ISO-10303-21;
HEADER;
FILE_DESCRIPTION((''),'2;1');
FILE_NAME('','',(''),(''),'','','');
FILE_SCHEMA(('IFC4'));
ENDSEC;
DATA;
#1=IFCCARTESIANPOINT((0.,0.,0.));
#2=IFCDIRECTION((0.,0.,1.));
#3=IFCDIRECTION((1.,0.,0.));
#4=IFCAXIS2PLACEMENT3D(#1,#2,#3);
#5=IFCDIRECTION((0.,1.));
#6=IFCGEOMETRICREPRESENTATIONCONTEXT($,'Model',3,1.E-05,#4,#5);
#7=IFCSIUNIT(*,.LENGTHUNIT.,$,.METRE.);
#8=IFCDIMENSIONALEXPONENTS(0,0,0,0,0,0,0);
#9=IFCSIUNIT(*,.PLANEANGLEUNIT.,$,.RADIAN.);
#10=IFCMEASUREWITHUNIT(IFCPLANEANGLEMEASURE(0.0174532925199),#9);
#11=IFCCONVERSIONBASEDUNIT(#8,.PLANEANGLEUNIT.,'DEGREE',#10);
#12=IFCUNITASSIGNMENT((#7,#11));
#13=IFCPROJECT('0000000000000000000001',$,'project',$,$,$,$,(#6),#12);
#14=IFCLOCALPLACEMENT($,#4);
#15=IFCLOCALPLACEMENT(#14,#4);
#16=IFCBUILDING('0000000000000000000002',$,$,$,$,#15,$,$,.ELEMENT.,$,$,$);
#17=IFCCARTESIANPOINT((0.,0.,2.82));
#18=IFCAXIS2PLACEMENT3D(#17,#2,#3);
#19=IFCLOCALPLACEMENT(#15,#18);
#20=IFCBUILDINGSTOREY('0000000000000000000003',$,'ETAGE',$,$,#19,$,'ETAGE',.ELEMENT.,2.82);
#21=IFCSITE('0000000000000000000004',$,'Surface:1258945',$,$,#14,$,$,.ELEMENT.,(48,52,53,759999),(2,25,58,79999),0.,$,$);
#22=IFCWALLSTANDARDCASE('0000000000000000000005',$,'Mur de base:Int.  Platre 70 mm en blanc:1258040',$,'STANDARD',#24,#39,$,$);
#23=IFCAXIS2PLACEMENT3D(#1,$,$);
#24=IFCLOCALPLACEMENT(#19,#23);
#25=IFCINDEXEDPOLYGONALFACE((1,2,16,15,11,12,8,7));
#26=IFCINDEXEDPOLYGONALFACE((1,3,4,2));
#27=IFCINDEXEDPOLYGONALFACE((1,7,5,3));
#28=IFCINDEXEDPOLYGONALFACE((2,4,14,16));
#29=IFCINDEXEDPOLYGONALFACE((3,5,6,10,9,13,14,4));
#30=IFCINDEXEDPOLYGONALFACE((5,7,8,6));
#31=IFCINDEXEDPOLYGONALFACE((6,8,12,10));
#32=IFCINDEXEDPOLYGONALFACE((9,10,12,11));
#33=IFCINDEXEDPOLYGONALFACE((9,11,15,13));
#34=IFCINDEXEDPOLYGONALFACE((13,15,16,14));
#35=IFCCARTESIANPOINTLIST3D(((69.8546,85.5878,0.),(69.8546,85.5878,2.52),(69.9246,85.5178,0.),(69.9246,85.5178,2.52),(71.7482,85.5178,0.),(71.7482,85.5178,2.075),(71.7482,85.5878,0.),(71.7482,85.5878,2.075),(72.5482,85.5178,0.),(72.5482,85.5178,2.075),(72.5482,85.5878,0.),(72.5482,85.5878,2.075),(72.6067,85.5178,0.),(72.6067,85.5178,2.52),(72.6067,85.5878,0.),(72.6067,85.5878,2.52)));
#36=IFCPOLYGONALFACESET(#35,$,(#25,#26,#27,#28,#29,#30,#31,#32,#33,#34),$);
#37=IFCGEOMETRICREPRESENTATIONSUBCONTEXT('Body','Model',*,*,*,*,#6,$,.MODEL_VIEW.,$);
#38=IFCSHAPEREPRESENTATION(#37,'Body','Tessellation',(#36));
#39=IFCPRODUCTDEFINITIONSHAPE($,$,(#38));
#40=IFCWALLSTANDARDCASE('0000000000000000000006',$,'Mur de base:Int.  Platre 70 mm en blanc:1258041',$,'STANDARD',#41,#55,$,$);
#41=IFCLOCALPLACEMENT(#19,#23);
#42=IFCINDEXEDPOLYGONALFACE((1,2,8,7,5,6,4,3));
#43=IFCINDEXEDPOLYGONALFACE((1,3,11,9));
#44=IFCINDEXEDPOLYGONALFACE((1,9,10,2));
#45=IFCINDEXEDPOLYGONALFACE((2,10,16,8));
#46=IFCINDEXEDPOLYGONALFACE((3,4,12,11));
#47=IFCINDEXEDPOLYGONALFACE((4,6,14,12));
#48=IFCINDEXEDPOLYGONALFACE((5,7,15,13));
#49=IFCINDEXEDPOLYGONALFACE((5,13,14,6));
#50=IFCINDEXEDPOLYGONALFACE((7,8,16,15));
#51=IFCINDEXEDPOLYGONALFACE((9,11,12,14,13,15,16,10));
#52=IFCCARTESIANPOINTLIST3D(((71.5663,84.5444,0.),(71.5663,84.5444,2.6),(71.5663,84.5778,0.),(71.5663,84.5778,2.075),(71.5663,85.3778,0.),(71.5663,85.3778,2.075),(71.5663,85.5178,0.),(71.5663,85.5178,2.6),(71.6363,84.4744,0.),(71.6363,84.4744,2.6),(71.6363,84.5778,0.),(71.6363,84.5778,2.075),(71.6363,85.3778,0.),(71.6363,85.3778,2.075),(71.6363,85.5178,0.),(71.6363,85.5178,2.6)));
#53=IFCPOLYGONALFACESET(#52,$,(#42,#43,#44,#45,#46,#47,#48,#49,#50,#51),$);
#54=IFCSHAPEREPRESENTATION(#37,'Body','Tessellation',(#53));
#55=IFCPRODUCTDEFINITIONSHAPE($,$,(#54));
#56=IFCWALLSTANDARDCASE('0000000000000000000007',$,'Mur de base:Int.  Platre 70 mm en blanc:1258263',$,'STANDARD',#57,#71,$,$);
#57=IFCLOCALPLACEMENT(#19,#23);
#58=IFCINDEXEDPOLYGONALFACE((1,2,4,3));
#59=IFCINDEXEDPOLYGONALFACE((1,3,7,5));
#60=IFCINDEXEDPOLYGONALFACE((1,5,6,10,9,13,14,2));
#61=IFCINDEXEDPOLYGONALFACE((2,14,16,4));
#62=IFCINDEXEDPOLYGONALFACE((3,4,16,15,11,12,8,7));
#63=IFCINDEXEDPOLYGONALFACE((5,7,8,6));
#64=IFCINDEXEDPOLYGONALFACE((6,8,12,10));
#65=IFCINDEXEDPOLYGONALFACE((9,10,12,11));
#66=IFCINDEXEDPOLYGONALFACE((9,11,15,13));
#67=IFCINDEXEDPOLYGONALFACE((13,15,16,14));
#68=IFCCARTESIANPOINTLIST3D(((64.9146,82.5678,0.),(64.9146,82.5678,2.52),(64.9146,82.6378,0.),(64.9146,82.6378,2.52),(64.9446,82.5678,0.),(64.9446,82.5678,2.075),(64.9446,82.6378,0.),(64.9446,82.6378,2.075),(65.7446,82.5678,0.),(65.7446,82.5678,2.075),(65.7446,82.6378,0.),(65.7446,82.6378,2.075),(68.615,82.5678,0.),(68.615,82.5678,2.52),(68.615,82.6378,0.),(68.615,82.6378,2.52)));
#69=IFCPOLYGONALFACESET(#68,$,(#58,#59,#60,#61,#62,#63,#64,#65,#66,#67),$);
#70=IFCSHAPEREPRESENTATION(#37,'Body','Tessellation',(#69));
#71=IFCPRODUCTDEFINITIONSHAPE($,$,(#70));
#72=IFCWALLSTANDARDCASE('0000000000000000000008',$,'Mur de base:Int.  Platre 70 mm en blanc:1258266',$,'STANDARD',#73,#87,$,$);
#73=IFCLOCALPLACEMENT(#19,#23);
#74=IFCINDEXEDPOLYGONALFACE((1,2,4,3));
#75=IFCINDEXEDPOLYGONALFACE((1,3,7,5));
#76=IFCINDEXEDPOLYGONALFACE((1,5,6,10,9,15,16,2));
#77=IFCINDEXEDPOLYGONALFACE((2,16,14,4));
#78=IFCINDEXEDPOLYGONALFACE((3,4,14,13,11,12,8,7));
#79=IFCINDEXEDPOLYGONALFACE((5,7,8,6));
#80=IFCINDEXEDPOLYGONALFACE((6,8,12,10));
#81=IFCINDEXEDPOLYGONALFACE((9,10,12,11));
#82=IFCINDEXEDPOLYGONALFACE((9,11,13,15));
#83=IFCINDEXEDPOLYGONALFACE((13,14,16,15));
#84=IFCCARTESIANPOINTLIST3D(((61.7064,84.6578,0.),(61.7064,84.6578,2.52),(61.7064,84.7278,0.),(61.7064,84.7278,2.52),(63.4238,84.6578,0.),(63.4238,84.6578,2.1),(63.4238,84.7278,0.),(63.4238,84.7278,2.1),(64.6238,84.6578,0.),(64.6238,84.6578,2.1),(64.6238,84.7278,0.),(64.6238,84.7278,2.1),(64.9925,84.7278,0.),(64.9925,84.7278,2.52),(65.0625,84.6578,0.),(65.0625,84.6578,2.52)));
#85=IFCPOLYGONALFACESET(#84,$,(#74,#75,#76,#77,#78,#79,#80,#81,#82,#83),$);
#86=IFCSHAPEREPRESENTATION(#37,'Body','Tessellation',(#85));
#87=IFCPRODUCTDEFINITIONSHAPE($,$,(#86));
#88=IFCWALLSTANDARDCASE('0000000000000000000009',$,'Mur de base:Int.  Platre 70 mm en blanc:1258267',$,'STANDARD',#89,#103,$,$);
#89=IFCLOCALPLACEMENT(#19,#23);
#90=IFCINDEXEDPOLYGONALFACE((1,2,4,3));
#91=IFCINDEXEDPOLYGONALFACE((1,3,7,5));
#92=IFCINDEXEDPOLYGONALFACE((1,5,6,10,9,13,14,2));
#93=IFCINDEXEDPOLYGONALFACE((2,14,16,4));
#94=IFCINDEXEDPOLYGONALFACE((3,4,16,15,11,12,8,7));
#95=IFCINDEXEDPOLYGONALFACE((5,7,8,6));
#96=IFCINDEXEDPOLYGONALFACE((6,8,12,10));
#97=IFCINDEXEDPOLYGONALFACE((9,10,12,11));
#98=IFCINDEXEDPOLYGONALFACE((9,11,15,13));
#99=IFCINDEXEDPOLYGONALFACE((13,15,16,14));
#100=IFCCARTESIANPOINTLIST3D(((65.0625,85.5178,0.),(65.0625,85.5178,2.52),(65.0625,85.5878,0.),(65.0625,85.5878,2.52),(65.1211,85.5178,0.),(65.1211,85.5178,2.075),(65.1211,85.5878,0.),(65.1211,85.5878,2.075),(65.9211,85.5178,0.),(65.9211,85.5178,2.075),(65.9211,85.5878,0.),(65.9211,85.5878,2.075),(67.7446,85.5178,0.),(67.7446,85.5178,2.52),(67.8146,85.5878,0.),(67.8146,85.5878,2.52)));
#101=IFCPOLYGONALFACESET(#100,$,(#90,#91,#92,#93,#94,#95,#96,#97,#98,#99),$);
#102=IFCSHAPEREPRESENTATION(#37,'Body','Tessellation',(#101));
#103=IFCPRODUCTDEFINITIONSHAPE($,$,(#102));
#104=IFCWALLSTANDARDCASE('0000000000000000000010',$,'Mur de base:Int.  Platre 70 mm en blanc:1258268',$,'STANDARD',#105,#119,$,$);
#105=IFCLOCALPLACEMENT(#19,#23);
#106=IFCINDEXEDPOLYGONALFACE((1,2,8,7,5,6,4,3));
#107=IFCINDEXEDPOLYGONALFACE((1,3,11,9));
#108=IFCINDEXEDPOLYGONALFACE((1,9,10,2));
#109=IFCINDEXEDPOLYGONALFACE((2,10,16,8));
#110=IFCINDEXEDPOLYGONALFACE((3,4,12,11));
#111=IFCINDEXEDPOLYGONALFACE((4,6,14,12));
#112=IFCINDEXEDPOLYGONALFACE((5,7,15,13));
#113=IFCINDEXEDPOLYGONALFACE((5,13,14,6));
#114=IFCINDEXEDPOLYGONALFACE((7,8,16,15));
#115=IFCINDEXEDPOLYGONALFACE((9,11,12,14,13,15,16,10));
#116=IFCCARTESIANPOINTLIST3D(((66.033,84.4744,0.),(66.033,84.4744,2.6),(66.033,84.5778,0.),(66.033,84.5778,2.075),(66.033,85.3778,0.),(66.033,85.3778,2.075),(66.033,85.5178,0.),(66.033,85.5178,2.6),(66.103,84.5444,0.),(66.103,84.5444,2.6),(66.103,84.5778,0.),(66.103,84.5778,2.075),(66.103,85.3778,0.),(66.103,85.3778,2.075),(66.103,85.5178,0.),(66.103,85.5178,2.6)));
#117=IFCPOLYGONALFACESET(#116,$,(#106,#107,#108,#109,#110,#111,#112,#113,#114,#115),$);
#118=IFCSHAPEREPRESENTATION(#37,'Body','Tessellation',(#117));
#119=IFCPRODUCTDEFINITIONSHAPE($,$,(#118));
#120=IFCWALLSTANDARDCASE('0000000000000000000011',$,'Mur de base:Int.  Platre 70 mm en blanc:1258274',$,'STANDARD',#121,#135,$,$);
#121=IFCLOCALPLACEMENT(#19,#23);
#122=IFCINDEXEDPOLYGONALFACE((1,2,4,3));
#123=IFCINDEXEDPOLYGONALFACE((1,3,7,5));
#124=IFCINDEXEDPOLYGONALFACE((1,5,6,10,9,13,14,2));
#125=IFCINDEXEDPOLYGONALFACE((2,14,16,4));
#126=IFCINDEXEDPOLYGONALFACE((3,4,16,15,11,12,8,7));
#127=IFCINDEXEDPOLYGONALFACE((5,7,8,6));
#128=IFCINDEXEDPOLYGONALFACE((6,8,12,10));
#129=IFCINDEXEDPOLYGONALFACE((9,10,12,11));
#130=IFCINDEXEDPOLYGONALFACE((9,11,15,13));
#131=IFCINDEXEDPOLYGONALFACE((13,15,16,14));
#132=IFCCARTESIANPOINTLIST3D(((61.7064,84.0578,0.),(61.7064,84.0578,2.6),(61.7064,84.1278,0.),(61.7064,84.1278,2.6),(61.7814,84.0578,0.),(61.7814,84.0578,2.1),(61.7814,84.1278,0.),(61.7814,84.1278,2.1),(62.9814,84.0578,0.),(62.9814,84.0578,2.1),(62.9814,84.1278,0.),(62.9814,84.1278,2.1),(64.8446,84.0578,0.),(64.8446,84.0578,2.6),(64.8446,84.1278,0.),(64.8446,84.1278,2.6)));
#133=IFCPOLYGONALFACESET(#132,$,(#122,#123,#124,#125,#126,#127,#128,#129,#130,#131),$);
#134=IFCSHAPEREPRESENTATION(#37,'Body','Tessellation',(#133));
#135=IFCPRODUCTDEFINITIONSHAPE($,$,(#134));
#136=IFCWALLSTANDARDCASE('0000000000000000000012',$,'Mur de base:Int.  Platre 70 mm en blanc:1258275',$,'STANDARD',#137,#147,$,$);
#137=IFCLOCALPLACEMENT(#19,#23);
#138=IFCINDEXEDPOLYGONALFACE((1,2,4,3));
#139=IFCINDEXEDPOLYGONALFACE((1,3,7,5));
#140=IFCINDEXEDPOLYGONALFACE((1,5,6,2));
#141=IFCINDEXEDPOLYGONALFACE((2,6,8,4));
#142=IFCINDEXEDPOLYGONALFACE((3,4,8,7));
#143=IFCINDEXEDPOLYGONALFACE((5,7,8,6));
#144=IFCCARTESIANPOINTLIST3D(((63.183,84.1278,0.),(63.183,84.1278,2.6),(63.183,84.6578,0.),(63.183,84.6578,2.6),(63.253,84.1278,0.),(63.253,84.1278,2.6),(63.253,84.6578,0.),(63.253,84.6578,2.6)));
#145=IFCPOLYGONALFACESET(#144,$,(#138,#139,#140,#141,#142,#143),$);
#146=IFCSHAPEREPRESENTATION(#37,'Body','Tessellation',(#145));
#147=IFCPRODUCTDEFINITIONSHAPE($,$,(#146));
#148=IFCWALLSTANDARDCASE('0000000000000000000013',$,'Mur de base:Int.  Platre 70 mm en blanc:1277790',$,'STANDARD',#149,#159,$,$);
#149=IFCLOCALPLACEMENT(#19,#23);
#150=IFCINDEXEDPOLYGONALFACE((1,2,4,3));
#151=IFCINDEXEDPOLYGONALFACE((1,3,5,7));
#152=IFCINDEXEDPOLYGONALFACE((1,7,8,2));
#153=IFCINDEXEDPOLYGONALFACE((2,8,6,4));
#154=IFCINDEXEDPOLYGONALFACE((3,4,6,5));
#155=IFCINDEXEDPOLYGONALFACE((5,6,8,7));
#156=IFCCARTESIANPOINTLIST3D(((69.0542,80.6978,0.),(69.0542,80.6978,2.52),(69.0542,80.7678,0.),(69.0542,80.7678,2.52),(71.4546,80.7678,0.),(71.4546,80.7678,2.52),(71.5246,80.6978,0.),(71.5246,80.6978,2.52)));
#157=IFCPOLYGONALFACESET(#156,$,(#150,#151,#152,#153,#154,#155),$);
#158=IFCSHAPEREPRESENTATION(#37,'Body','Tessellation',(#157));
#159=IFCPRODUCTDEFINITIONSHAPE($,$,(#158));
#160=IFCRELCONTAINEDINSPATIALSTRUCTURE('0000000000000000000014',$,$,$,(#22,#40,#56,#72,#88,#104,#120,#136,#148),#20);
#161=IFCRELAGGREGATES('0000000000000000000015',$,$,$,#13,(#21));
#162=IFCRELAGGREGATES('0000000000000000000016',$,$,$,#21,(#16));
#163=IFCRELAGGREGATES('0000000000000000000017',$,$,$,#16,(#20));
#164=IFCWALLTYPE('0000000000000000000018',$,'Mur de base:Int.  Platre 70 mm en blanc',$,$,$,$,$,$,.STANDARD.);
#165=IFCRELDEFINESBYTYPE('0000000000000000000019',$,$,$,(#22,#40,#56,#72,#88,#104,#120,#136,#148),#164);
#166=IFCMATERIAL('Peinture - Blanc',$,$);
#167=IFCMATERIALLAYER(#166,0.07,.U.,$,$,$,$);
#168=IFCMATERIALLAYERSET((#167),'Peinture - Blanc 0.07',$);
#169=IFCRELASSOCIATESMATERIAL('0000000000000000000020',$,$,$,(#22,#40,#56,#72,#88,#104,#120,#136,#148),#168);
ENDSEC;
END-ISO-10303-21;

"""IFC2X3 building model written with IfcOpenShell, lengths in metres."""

from ifc_helpers import new_model, entity, si_unit, converted_unit, direction, frame, origin_with_axes, place, context, subcontext, project, spatial, polyline, outline, extrude, material, layer, layer_set, layer_usage, type_object, element, save


model = new_model("IFC2X3")

# Units and contexts
model_context = context("Model", 3, precision=1e-05, world=origin_with_axes(), true_north=direction((0.0, 1.0)))
body_context = subcontext(model_context, "Body", "Model", "MODEL_VIEW")
ifc_project = project(units=[si_unit("LENGTHUNIT", "METRE"), converted_unit("PLANEANGLEUNIT", "DEGREE", entity("IfcPlaneAngleMeasure", 0.0174532925199), si_unit("PLANEANGLEUNIT", "RADIAN"), dimensions=[0, 0, 0, 0, 0, 0, 0])], contexts=[model_context])

# Site, building, storey
site_placement = place(None, origin_with_axes())
site = spatial("IfcSite", under=ifc_project, at=site_placement, Name="Surface:1258945", CompositionType="ELEMENT", RefLatitude=(48, 52, 53, 759999), RefLongitude=(2, 25, 58, 79999), RefElevation=0.0)
building_placement = place(site_placement, origin_with_axes())
building = spatial("IfcBuilding", under=site, at=building_placement, CompositionType="ELEMENT")
storey_placement = place(building_placement, frame((0.0, 0.0, 2.82), z_axis=(0.0, 0.0, 1.0), x_axis=(1.0, 0.0, 0.0)))
storey = spatial("IfcBuildingStorey", under=building, at=storey_placement, Name="ETAGE", LongName="ETAGE", CompositionType="ELEMENT", Elevation=2.82)

# Shared definitions
ifc_material_1 = material(Name="Peinture - Blanc")
ifc_layer_1 = layer(ifc_material_1, 0.07, ventilated="UNKNOWN")
ifc_layer_set_1 = layer_set([ifc_layer_1], Name="Peinture - Blanc 0.07")
wall_type_1 = type_object("IfcWallType", Name="Mur de base:Int.  Platre 70 mm en blanc", PredefinedType="STANDARD")

# Walls, openings
ifc_layer_usage_1 = layer_usage(ifc_layer_set_1, "AXIS2", "POSITIVE", -0.035)
wall_1_placement = place(storey_placement, frame((69.8896, 85.5528, 0.0), z_axis=(0.0, 0.0, 1.0), x_axis=(1.0, 0.0, 0.0)))
wall_1 = element("IfcWallStandardCase", 1, at=wall_1_placement, inside=storey, type_object=wall_type_1, material=ifc_layer_usage_1, Name="Mur de base:Int.  Platre 70 mm en blanc:1258040", ObjectType="STANDARD", context=body_context, shape_type="SweptSolid", body=[
    extrude(outline(polyline([(0.035, -0.035), (2.7171, -0.035), (2.7171, 0.035), (-0.035, 0.035), (0.035, -0.035)])), origin_with_axes(), (0.0, 0.0, 1.0), 2.52),
])
opening_1_placement = place(wall_1_placement, frame((2.2586, 0.0, 0.0), z_axis=(0.0, 0.0, 1.0), x_axis=(1.0, 0.0, 0.0)))
element("IfcOpeningElement", 2, at=opening_1_placement, cuts=wall_1, context=body_context, shape_type="SweptSolid", body=[
    extrude(outline(polyline([(0.4, 0.0), (0.4, 2.075), (-0.4, 2.075), (-0.4, 0.0), (0.4, 0.0)])), frame((0.0, -0.035, 0.0), z_axis=(0.0, 1.0, 0.0), x_axis=(-1.0, 0.0, 0.0)), (0.0, 0.0, 1.0), 0.07),
])
ifc_layer_usage_2 = layer_usage(ifc_layer_set_1, "AXIS2", "POSITIVE", -0.035)
wall_2_placement = place(storey_placement, frame((71.6013, 84.5094, 0.0), z_axis=(0.0, 0.0, 1.0), x_axis=(0.0, 1.0, 0.0)))
wall_2 = element("IfcWallStandardCase", 3, at=wall_2_placement, inside=storey, type_object=wall_type_1, material=ifc_layer_usage_2, Name="Mur de base:Int.  Platre 70 mm en blanc:1258041", ObjectType="STANDARD", context=body_context, shape_type="SweptSolid", body=[
    extrude(outline(polyline([(-0.035, -0.035), (1.0083, -0.035), (1.0083, 0.035), (0.035, 0.035), (-0.035, -0.035)])), origin_with_axes(), (0.0, 0.0, 1.0), 2.6),
])
opening_2_placement = place(wall_2_placement, frame((0.4683, 0.0, 0.0), z_axis=(0.0, 0.0, 1.0), x_axis=(1.0, 0.0, 0.0)))
element("IfcOpeningElement", 4, at=opening_2_placement, cuts=wall_2, context=body_context, shape_type="SweptSolid", body=[
    extrude(outline(polyline([(-0.4, 0.0), (0.4, 0.0), (0.4, 2.075), (-0.4, 2.075), (-0.4, 0.0)])), frame((0.0, 0.035, 0.0), z_axis=(0.0, 1.0, 0.0), x_axis=(-1.0, 0.0, 0.0)), (0.0, 0.0, -1.0), 0.07),
])
ifc_layer_usage_3 = layer_usage(ifc_layer_set_1, "AXIS2", "POSITIVE", -0.035)
wall_3_placement = place(storey_placement, frame((64.8796, 82.6028, 0.0), z_axis=(0.0, 0.0, 1.0), x_axis=(1.0, 0.0, 0.0)))
wall_3 = element("IfcWallStandardCase", 5, at=wall_3_placement, inside=storey, type_object=wall_type_1, material=ifc_layer_usage_3, Name="Mur de base:Int.  Platre 70 mm en blanc:1258263", ObjectType="STANDARD", context=body_context, shape_type="SweptSolid", body=[
    extrude(outline(polyline([(0.035, -0.035), (3.7354, -0.035), (3.7354, 0.035), (0.035, 0.035), (0.035, -0.035)])), origin_with_axes(), (0.0, 0.0, 1.0), 2.52),
])
opening_3_placement = place(wall_3_placement, frame((0.465, 0.0, 0.0), z_axis=(0.0, 0.0, 1.0), x_axis=(1.0, 0.0, 0.0)))
element("IfcOpeningElement", 6, at=opening_3_placement, cuts=wall_3, context=body_context, shape_type="SweptSolid", body=[
    extrude(outline(polyline([(0.4, 0.0), (0.4, 2.075), (-0.4, 2.075), (-0.4, 0.0), (0.4, 0.0)])), frame((0.0, 0.035, 0.0), z_axis=(0.0, -1.0, 0.0), x_axis=(1.0, 0.0, 0.0)), (0.0, 0.0, 1.0), 0.07),
])

# Walls, openings
ifc_layer_usage_4 = layer_usage(ifc_layer_set_1, "AXIS2", "POSITIVE", -0.035)
wall_4_placement = place(storey_placement, frame((65.0275, 84.6928, 0.0), z_axis=(0.0, 0.0, 1.0), x_axis=(-1.0, 0.0, 0.0)))
wall_4 = element("IfcWallStandardCase", 7, at=wall_4_placement, inside=storey, type_object=wall_type_1, material=ifc_layer_usage_4, Name="Mur de base:Int.  Platre 70 mm en blanc:1258266", ObjectType="STANDARD", context=body_context, shape_type="SweptSolid", body=[
    extrude(outline(polyline([(0.035, -0.035), (3.3211, -0.035), (3.3211, 0.035), (-0.035, 0.035), (0.035, -0.035)])), origin_with_axes(), (0.0, 0.0, 1.0), 2.52),
])
opening_4_placement = place(wall_4_placement, frame((1.0037, 0.0, 0.0), z_axis=(0.0, 0.0, 1.0), x_axis=(1.0, 0.0, 0.0)))
element("IfcOpeningElement", 8, at=opening_4_placement, cuts=wall_4, context=body_context, shape_type="SweptSolid", body=[
    extrude(outline(polyline([(0.6, 0.0), (0.6, 2.1), (-0.6, 2.1), (-0.6, 0.0), (0.6, 0.0)])), frame((0.0, 0.035, 0.0), z_axis=(0.0, -1.0, 0.0), x_axis=(1.0, 0.0, 0.0)), (0.0, 0.0, 1.0), 0.07),
])
ifc_layer_usage_5 = layer_usage(ifc_layer_set_1, "AXIS2", "POSITIVE", -0.035)
wall_5_placement = place(storey_placement, frame((67.7796, 85.5528, 0.0), z_axis=(0.0, 0.0, 1.0), x_axis=(-1.0, 0.0, 0.0)))
wall_5 = element("IfcWallStandardCase", 9, at=wall_5_placement, inside=storey, type_object=wall_type_1, material=ifc_layer_usage_5, Name="Mur de base:Int.  Platre 70 mm en blanc:1258267", ObjectType="STANDARD", context=body_context, shape_type="SweptSolid", body=[
    extrude(outline(polyline([(-0.035, -0.035), (2.7171, -0.035), (2.7171, 0.035), (0.035, 0.035), (-0.035, -0.035)])), origin_with_axes(), (0.0, 0.0, 1.0), 2.52),
])
opening_5_placement = place(wall_5_placement, frame((2.2586, 0.0, 0.0), z_axis=(0.0, 0.0, 1.0), x_axis=(1.0, 0.0, 0.0)))
element("IfcOpeningElement", 10, at=opening_5_placement, cuts=wall_5, context=body_context, shape_type="SweptSolid", body=[
    extrude(outline(polyline([(-0.4, 0.0), (0.4, 0.0), (0.4, 2.075), (-0.4, 2.075), (-0.4, 0.0)])), frame((0.0, 0.035, 0.0), z_axis=(0.0, 1.0, 0.0), x_axis=(-1.0, 0.0, 0.0)), (0.0, 0.0, -1.0), 0.07),
])
ifc_layer_usage_6 = layer_usage(ifc_layer_set_1, "AXIS2", "POSITIVE", -0.035)
wall_6_placement = place(storey_placement, frame((66.068, 84.5094, 0.0), z_axis=(0.0, 0.0, 1.0), x_axis=(0.0, 1.0, 0.0)))
wall_6 = element("IfcWallStandardCase", 11, at=wall_6_placement, inside=storey, type_object=wall_type_1, material=ifc_layer_usage_6, Name="Mur de base:Int.  Platre 70 mm en blanc:1258268", ObjectType="STANDARD", context=body_context, shape_type="SweptSolid", body=[
    extrude(outline(polyline([(0.035, -0.035), (1.0083, -0.035), (1.0083, 0.035), (-0.035, 0.035), (0.035, -0.035)])), origin_with_axes(), (0.0, 0.0, 1.0), 2.6),
])
opening_6_placement = place(wall_6_placement, frame((0.4683, 0.0, 0.0), z_axis=(0.0, 0.0, 1.0), x_axis=(1.0, 0.0, 0.0)))
element("IfcOpeningElement", 12, at=opening_6_placement, cuts=wall_6, context=body_context, shape_type="SweptSolid", body=[
    extrude(outline(polyline([(0.4, 0.0), (0.4, 2.075), (-0.4, 2.075), (-0.4, 0.0), (0.4, 0.0)])), frame((0.0, -0.035, 0.0), z_axis=(0.0, 1.0, 0.0), x_axis=(-1.0, 0.0, 0.0)), (0.0, 0.0, 1.0), 0.07),
])
ifc_layer_usage_7 = layer_usage(ifc_layer_set_1, "AXIS2", "POSITIVE", -0.035)
wall_7_placement = place(storey_placement, frame((64.8796, 84.0928, 0.0), z_axis=(0.0, 0.0, 1.0), x_axis=(-1.0, 0.0, 0.0)))
wall_7 = element("IfcWallStandardCase", 13, at=wall_7_placement, inside=storey, type_object=wall_type_1, material=ifc_layer_usage_7, Name="Mur de base:Int.  Platre 70 mm en blanc:1258274", ObjectType="STANDARD", context=body_context, shape_type="SweptSolid", body=[
    extrude(outline(polyline([(0.035, -0.035), (3.1733, -0.035), (3.1733, 0.035), (0.035, 0.035), (0.035, -0.035)])), origin_with_axes(), (0.0, 0.0, 1.0), 2.6),
])
opening_7_placement = place(wall_7_placement, frame((2.4983, 0.0, 0.0), z_axis=(0.0, 0.0, 1.0), x_axis=(1.0, 0.0, 0.0)))
element("IfcOpeningElement", 14, at=opening_7_placement, cuts=wall_7, context=body_context, shape_type="SweptSolid", body=[
    extrude(outline(polyline([(0.6, 0.0), (0.6, 2.1), (-0.6, 2.1), (-0.6, 0.0), (0.6, 0.0)])), frame((0.0, 0.035, 0.0), z_axis=(0.0, -1.0, 0.0), x_axis=(1.0, 0.0, 0.0)), (0.0, 0.0, 1.0), 0.07),
])

# Walls
ifc_layer_usage_8 = layer_usage(ifc_layer_set_1, "AXIS2", "POSITIVE", -0.035)
wall_8_placement = place(storey_placement, frame((63.218, 84.0928, 0.0), z_axis=(0.0, 0.0, 1.0), x_axis=(0.0, 1.0, 0.0)))
element("IfcWallStandardCase", 15, at=wall_8_placement, inside=storey, type_object=wall_type_1, material=ifc_layer_usage_8, Name="Mur de base:Int.  Platre 70 mm en blanc:1258275", ObjectType="STANDARD", context=body_context, shape_type="SweptSolid", body=[
    extrude(outline(polyline([(0.035, -0.035), (0.565, -0.035), (0.565, 0.035), (0.035, 0.035), (0.035, -0.035)])), origin_with_axes(), (0.0, 0.0, 1.0), 2.6),
])
ifc_layer_usage_9 = layer_usage(ifc_layer_set_1, "AXIS2", "POSITIVE", -0.035)
wall_9_placement = place(storey_placement, frame((71.4896, 80.7328, 0.0), z_axis=(0.0, 0.0, 1.0), x_axis=(-1.0, 0.0, 0.0)))
element("IfcWallStandardCase", 16, at=wall_9_placement, inside=storey, type_object=wall_type_1, material=ifc_layer_usage_9, Name="Mur de base:Int.  Platre 70 mm en blanc:1277790", ObjectType="STANDARD", context=body_context, shape_type="SweptSolid", body=[
    extrude(outline(polyline([(0.035, -0.035), (2.4354, -0.035), (2.4354, 0.035), (-0.035, 0.035), (0.035, -0.035)])), origin_with_axes(), (0.0, 0.0, 1.0), 2.52),
])

save(model, "model.ifc")
